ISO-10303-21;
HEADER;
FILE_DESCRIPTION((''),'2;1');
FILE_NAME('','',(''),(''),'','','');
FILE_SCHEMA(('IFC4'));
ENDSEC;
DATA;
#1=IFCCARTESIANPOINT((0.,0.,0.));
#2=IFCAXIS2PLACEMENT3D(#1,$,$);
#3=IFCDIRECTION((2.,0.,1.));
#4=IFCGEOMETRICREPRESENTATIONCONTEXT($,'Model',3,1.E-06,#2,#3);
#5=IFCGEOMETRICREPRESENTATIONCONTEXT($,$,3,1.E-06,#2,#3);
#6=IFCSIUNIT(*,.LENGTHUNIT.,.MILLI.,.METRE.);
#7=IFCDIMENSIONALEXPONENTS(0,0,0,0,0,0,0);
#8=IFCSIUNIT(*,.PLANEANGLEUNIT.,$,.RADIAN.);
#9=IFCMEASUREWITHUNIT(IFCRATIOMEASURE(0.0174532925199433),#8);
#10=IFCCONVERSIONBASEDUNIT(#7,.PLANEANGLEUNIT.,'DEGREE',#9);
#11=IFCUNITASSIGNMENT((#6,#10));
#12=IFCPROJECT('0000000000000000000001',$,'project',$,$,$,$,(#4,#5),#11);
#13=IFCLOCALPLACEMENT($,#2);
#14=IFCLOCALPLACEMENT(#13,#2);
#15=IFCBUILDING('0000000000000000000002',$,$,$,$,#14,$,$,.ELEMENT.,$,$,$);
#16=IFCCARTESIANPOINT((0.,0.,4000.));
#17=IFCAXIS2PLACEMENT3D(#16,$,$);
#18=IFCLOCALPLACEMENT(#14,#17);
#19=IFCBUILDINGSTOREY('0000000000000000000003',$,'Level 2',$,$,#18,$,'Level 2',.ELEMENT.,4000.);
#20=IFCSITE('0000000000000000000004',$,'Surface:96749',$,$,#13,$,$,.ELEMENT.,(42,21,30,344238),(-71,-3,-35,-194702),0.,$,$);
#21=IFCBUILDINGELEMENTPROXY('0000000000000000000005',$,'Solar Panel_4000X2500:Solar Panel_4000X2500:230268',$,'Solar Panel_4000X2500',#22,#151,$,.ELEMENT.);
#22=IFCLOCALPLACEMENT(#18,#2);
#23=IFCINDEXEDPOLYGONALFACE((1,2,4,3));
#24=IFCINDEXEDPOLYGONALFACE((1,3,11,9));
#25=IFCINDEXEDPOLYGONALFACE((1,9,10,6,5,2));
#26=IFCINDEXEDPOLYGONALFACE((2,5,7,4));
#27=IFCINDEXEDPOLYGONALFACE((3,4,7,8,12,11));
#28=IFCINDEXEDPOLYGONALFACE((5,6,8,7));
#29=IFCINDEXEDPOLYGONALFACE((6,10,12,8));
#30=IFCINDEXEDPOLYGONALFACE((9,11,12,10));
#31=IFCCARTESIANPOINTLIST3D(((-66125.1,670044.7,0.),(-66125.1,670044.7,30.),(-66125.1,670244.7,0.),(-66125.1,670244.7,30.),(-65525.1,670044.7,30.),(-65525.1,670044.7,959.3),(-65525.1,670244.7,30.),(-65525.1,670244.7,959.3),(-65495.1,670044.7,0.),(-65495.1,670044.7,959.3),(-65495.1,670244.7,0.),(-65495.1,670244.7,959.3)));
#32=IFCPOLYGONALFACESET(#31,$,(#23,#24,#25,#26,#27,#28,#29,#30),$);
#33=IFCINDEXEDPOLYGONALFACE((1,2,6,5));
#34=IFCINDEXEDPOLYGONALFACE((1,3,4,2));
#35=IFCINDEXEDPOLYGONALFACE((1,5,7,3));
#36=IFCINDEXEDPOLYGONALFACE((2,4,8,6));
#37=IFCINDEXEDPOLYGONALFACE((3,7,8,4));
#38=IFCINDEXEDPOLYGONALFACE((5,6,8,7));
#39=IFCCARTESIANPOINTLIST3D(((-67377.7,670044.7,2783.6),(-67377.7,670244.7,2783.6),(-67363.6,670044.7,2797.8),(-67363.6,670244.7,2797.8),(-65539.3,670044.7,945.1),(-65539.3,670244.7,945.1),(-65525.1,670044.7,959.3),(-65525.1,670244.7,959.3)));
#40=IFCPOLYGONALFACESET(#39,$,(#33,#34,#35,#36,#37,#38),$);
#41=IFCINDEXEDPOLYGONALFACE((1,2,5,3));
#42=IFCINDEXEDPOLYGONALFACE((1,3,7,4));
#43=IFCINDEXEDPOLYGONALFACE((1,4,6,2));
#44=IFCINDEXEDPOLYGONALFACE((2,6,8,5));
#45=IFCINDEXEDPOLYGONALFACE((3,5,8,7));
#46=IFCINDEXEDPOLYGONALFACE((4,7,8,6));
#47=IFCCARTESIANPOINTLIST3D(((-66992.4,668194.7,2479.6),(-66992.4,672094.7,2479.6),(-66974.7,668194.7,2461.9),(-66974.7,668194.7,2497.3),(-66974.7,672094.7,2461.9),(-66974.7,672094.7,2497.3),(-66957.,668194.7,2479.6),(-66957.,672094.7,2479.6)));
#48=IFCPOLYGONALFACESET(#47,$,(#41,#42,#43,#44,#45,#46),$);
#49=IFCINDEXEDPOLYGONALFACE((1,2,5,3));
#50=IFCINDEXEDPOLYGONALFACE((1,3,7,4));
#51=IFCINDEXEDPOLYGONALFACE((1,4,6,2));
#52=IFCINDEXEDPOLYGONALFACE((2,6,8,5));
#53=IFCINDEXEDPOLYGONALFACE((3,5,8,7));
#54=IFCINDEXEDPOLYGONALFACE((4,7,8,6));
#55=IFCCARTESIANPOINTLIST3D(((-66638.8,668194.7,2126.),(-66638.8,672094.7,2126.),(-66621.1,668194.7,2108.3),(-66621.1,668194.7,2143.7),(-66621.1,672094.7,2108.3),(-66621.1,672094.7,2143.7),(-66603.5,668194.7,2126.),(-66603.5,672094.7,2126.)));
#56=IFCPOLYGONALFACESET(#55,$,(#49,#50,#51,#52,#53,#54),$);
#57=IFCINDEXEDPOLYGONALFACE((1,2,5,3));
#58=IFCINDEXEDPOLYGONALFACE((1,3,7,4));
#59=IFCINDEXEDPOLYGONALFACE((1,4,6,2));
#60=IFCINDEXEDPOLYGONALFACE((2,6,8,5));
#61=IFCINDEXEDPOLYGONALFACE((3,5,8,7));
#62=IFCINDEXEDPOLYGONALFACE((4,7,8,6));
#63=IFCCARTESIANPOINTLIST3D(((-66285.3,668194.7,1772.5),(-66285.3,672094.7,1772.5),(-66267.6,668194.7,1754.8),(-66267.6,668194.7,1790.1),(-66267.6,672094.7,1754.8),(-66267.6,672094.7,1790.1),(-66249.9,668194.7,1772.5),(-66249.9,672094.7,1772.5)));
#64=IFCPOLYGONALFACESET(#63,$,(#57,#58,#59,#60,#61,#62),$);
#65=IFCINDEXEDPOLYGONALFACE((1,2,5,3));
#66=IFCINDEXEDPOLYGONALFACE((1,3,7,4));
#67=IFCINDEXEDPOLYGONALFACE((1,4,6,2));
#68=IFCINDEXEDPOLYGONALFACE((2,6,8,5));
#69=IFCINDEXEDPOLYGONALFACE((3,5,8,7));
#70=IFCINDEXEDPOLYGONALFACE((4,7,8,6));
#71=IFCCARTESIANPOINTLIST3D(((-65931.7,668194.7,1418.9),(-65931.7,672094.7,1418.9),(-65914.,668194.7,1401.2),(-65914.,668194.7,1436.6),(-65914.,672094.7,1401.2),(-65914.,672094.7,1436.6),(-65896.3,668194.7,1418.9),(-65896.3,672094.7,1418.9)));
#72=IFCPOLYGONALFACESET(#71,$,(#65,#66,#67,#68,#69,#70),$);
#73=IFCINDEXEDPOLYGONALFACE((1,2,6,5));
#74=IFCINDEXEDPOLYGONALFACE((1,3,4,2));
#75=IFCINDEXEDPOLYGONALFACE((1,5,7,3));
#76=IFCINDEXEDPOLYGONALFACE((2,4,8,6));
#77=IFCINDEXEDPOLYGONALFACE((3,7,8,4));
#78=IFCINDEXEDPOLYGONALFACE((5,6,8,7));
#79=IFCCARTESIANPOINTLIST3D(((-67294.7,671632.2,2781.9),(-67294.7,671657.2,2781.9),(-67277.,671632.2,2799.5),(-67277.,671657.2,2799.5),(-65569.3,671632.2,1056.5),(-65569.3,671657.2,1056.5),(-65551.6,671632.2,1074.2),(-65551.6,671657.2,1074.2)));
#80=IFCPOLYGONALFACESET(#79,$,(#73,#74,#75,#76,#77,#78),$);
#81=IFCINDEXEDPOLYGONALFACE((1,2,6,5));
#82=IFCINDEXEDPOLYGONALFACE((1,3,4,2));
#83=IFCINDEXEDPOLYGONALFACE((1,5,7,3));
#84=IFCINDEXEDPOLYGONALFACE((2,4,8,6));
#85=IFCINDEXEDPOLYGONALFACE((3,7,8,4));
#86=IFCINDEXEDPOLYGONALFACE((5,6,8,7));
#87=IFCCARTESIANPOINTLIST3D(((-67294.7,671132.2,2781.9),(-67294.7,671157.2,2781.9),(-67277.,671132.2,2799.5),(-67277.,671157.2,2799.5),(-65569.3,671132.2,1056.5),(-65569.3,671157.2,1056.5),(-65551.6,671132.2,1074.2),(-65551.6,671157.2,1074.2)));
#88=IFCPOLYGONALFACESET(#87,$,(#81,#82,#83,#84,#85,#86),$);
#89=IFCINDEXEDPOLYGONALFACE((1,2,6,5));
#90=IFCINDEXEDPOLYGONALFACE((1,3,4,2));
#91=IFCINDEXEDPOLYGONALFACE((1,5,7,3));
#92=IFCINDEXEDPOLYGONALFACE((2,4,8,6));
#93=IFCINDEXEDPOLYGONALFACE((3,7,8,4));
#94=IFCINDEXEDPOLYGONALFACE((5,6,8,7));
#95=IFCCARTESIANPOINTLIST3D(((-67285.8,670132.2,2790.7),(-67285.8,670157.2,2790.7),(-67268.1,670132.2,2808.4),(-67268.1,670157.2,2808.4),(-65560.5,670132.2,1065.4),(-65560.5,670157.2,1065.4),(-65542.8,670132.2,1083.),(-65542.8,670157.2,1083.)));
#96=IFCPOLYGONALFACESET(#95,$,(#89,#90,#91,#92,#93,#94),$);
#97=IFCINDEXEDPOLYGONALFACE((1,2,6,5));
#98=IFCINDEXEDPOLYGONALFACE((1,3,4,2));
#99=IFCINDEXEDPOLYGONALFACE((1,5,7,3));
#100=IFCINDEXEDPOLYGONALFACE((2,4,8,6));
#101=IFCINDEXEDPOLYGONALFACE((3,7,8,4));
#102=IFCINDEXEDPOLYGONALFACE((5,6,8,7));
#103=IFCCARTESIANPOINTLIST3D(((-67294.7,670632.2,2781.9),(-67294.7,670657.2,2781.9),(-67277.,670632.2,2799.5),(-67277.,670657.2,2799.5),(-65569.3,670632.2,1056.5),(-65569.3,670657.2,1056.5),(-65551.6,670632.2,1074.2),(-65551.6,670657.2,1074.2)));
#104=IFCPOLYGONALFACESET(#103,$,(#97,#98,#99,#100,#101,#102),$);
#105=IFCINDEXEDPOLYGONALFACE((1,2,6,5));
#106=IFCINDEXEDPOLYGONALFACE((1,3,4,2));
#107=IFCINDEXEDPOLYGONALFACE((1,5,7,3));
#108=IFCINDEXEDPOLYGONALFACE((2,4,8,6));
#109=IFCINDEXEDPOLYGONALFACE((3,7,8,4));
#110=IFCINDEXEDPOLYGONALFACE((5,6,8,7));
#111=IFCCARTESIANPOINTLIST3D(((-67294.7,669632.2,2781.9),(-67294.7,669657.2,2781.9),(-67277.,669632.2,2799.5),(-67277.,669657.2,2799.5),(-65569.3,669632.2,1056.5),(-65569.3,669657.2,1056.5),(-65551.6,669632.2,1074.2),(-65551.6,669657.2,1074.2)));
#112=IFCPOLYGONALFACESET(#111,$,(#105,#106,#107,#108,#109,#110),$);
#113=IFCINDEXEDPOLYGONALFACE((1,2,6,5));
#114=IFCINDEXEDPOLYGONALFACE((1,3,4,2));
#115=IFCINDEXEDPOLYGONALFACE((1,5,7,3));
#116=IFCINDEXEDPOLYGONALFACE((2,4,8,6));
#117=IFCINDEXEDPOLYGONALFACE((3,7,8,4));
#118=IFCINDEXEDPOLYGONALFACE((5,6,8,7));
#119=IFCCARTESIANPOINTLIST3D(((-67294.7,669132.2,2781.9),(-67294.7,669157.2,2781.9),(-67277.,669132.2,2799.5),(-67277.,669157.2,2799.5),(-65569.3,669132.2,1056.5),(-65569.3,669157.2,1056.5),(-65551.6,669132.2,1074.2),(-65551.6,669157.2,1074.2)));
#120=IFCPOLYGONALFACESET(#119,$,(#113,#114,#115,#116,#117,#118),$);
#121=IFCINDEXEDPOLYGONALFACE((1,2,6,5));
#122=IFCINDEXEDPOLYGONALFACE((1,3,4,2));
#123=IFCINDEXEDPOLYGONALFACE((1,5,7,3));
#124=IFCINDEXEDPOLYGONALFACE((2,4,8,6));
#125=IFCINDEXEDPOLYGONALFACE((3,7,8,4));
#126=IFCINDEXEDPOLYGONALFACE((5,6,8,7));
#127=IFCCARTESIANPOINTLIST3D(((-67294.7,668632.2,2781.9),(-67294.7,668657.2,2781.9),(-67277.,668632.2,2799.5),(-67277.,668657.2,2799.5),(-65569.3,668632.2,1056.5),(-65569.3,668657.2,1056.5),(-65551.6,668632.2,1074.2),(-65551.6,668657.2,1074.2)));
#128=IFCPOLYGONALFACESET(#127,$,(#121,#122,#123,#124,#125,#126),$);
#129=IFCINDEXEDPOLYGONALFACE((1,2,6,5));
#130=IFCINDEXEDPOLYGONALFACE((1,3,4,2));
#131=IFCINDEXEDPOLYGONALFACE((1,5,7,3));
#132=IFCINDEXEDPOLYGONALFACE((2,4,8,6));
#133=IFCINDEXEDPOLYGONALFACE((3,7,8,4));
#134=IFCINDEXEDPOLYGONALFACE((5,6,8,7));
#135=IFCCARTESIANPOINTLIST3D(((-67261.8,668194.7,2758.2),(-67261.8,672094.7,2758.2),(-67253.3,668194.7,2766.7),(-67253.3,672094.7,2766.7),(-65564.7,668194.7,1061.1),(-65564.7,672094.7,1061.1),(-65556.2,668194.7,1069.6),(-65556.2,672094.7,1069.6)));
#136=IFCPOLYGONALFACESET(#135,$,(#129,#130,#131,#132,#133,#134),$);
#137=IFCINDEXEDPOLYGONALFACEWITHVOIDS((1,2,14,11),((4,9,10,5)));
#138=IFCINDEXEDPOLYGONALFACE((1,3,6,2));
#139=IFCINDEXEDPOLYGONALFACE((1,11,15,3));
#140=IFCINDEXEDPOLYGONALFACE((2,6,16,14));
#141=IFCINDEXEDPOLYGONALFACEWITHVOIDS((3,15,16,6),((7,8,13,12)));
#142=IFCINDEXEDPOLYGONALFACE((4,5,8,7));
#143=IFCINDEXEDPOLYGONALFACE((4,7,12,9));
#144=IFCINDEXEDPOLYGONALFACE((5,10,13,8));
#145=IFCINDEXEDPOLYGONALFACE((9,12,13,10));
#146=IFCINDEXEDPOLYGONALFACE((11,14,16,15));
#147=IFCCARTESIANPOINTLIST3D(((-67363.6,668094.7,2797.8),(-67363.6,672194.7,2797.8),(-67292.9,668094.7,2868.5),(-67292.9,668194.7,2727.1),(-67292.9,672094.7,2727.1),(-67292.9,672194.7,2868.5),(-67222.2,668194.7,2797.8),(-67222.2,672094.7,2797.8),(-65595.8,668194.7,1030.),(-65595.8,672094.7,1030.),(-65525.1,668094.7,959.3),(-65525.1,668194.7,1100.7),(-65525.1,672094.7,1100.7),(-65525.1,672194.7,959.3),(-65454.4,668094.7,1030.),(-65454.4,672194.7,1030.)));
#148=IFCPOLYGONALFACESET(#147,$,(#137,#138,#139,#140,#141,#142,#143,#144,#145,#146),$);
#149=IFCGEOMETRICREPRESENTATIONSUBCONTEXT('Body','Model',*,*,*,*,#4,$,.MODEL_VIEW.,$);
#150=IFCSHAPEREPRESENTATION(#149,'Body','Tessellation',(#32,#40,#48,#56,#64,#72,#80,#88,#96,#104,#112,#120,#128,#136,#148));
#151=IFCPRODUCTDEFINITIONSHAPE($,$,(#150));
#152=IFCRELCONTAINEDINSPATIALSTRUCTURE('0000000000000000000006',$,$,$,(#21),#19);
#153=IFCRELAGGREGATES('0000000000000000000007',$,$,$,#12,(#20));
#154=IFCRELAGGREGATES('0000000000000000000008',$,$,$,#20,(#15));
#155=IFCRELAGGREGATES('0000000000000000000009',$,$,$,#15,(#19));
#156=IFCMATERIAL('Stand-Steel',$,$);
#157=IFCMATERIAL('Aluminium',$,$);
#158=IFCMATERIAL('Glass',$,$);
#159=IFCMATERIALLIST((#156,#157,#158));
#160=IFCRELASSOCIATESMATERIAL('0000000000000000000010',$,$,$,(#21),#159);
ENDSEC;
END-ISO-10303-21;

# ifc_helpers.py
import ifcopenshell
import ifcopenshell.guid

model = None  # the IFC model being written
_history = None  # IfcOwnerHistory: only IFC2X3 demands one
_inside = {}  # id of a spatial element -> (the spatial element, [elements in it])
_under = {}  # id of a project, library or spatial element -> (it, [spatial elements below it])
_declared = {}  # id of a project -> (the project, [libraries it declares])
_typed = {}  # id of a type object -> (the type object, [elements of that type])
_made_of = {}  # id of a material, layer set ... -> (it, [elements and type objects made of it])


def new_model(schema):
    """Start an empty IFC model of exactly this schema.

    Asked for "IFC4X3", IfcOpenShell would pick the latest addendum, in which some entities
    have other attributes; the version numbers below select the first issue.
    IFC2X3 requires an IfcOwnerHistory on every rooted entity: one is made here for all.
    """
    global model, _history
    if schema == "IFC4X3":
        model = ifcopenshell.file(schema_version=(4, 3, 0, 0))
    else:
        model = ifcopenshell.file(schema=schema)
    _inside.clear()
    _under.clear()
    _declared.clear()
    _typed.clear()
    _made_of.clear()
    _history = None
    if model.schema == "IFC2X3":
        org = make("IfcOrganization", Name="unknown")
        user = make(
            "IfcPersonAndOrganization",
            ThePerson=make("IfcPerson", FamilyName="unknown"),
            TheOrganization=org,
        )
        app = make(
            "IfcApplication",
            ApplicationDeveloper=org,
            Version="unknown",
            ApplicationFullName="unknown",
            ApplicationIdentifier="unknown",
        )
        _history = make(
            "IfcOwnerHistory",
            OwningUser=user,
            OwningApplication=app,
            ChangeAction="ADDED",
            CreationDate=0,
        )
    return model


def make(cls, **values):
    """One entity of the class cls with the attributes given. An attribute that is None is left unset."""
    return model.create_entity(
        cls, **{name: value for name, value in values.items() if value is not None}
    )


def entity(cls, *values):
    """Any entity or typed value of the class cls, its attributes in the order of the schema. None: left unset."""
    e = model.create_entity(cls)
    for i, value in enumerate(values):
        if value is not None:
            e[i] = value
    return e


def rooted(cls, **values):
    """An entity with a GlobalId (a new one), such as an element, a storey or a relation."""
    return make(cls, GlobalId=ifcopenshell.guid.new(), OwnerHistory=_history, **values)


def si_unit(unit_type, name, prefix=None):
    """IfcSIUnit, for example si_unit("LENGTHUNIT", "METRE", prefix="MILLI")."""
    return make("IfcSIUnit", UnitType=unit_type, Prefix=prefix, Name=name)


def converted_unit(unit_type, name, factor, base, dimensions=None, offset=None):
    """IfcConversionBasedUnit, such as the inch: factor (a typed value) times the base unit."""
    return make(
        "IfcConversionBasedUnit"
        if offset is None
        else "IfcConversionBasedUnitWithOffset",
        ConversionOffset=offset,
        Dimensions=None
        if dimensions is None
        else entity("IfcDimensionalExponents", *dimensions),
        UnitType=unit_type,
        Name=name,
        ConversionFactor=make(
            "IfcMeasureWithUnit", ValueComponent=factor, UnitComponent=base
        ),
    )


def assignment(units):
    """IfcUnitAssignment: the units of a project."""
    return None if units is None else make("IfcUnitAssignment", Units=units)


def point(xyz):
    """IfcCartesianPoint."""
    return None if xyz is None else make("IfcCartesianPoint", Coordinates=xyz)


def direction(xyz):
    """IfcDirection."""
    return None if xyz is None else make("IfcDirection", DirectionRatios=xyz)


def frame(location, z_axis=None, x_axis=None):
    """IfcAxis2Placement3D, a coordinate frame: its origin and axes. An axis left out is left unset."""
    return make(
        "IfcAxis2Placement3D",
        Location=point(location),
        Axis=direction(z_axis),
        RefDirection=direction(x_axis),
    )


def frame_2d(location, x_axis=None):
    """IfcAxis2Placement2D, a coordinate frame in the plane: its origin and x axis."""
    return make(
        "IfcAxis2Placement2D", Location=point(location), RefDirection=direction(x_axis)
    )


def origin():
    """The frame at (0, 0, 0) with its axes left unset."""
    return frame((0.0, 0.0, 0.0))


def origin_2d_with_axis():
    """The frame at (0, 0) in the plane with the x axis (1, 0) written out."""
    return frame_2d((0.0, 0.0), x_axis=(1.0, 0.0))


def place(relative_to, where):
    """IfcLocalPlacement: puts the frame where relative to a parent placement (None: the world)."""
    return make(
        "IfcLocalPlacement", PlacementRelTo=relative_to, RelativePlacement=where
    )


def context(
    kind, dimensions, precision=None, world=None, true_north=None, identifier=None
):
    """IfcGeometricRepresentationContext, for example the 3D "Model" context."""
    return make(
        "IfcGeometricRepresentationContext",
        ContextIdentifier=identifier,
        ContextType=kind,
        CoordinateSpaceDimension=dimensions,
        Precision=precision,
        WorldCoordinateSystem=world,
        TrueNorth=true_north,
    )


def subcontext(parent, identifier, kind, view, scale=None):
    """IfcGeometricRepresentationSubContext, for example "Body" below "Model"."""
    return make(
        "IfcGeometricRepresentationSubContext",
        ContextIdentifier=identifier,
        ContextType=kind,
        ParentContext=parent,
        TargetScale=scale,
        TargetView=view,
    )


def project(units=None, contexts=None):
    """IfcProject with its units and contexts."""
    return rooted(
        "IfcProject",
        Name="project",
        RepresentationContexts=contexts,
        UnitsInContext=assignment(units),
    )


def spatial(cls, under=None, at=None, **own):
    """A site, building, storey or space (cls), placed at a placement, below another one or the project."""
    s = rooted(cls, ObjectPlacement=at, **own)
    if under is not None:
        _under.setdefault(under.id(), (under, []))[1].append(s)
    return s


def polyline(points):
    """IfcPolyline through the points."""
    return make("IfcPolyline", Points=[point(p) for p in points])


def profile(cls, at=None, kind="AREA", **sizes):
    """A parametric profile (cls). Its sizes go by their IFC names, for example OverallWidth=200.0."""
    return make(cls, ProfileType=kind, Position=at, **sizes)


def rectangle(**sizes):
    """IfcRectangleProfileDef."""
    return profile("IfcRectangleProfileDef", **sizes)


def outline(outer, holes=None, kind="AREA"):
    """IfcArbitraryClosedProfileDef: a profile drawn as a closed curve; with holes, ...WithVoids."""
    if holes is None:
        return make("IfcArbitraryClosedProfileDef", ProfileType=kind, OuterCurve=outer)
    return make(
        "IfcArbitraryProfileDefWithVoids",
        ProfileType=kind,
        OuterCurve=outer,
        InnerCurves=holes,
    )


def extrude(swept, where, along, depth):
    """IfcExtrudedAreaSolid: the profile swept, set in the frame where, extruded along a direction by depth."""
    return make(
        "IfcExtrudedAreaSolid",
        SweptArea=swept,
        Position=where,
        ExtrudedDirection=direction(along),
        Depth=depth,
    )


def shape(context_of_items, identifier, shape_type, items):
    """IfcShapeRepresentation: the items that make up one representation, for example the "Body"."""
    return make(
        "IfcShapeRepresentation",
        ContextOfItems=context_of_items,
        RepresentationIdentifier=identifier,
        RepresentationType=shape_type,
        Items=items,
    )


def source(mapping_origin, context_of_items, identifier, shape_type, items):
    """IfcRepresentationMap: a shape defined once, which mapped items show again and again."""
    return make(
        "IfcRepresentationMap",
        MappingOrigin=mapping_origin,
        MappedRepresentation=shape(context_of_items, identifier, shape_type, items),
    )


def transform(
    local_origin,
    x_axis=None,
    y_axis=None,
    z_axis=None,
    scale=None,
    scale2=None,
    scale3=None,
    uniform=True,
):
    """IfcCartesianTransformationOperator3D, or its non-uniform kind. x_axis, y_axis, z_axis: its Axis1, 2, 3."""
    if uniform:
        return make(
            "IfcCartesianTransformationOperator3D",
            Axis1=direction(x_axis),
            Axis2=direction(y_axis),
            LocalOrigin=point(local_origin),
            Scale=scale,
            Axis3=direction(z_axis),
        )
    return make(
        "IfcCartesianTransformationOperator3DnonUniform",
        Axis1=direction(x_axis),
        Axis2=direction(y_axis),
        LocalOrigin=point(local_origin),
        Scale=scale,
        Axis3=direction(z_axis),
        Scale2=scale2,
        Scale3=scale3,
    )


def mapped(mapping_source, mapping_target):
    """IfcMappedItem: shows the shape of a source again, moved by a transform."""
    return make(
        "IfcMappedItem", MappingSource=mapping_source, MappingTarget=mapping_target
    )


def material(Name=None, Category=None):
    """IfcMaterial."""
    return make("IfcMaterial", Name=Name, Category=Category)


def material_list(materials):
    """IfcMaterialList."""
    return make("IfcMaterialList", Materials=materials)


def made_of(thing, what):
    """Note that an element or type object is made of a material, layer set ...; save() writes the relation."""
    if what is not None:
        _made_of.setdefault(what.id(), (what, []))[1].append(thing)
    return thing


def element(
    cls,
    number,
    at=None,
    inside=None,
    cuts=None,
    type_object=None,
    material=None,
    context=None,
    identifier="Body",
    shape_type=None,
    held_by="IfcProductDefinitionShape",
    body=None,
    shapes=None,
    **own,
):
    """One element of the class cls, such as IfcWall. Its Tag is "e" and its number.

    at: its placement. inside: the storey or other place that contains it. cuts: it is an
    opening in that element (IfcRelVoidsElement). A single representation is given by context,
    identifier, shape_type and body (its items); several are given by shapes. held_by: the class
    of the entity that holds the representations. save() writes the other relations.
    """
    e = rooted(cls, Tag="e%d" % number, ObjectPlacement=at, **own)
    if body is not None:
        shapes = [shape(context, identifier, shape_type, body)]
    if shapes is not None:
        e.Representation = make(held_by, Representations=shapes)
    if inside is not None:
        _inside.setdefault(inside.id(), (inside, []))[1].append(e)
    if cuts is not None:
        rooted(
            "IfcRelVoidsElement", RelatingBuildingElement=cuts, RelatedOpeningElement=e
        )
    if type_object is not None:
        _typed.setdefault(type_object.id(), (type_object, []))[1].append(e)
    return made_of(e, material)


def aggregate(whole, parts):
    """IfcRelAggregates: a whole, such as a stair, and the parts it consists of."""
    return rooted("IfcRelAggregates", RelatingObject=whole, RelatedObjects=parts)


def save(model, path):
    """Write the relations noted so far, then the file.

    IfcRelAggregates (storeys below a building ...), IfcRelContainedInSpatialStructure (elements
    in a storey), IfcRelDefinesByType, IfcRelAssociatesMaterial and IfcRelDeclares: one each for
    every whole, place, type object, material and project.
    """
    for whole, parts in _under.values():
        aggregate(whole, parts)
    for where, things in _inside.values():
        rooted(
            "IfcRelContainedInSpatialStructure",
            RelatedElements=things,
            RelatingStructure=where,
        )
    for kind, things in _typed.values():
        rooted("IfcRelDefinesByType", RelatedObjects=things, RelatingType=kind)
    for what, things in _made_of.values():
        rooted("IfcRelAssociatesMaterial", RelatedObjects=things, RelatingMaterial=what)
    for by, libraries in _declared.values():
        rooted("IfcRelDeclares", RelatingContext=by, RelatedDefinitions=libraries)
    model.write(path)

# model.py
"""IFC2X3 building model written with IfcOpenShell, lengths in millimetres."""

from ifc_helpers import new_model, entity, si_unit, converted_unit, direction, frame, frame_2d, origin, origin_2d_with_axis, place, context, subcontext, project, spatial, polyline, rectangle, outline, extrude, source, transform, mapped, material, material_list, element, save


model = new_model("IFC2X3")

# Units and contexts
model_context = context("Model", 3, precision=1e-06, world=origin(), true_north=direction((2.0, 0.0, 1.0)))
context_of_model = context(None, 3, precision=1e-06, world=origin(), true_north=direction((2.0, 0.0, 1.0)))
body_context = subcontext(model_context, "Body", "Model", "MODEL_VIEW")
ifc_project = project(units=[si_unit("LENGTHUNIT", "METRE", prefix="MILLI"), converted_unit("PLANEANGLEUNIT", "DEGREE", entity("IfcRatioMeasure", 0.0174532925199433), si_unit("PLANEANGLEUNIT", "RADIAN"), dimensions=[0, 0, 0, 0, 0, 0, 0])], contexts=[model_context, context_of_model])

# Site, building, storey
site_placement = place(None, origin())
site = spatial("IfcSite", under=ifc_project, at=site_placement, Name="Surface:96749", CompositionType="ELEMENT", RefLatitude=(42, 21, 30, 344238), RefLongitude=(-71, -3, -35, -194702), RefElevation=0.0)
building_placement = place(site_placement, origin())
building = spatial("IfcBuilding", under=site, at=building_placement, CompositionType="ELEMENT")
storey_placement = place(building_placement, frame((0.0, 0.0, 4000.0)))
storey = spatial("IfcBuildingStorey", under=building, at=storey_placement, Name="Level 2", LongName="Level 2", CompositionType="ELEMENT", Elevation=4000.0)

# Building element proxy
ifc_material_1 = material(Name="Stand-Steel")
ifc_material_2 = material(Name="Aluminium")
ifc_material_3 = material(Name="Glass")
ifc_material_list_1 = material_list([ifc_material_1, ifc_material_2, ifc_material_3])
shared_shape = source(origin(), body_context, "Body", "SweptSolid", [
    extrude(outline(polyline([(-629.5, -220.0), (329.8, -220.0), (329.8, 410.0), (299.8, 410.0), (299.8, -190.0), (-629.5, -190.0), (-629.5, -220.0)])), frame((-190.0, -100.0, 299.8), z_axis=(0.0, 1.0, 0.0), x_axis=(0.0, 0.0, -1.0)), (0.0, 0.0, 1.0), 200.0),
    extrude(rectangle(XDim=20.0, YDim=200.0, at=frame_2d((0.0, 0.0), x_axis=(0.0, 1.0))), frame((-7.1, 0.0, 922.2), z_axis=(-0.707107, 0.0, 0.707107), x_axis=(0.0, 1.0, 0.0)), (0.0, 0.0, 1.0), 2600.0),
    extrude(rectangle(XDim=25.0, YDim=25.0, at=frame_2d((0.0, 0.0), x_axis=(1.0, 0.0))), frame((-1449.6, -1950.0, 2449.6), z_axis=(0.0, 1.0, 0.0), x_axis=(-0.707107, 0.0, -0.707107)), (0.0, 0.0, 1.0), 3900.0),
    extrude(rectangle(XDim=25.0, YDim=25.0, at=origin_2d_with_axis()), frame((-1096.0, -1950.0, 2096.0), z_axis=(0.0, 1.0, 0.0), x_axis=(-0.707107, 0.0, -0.707107)), (0.0, 0.0, 1.0), 3900.0),
    extrude(rectangle(XDim=25.0, YDim=25.0, at=origin_2d_with_axis()), frame((-742.5, -1950.0, 1742.5), z_axis=(0.0, 1.0, 0.0), x_axis=(-0.707107, 0.0, -0.707107)), (0.0, 0.0, 1.0), 3900.0),
    extrude(rectangle(XDim=25.0, YDim=25.0, at=frame_2d((0.0, 0.0), x_axis=(1.0, 0.0))), frame((-388.9, -1950.0, 1388.9), z_axis=(0.0, 1.0, 0.0), x_axis=(-0.707107, 0.0, -0.707107)), (0.0, 0.0, 1.0), 3900.0),
    extrude(rectangle(XDim=25.0, YDim=25.0, at=frame_2d((0.0, 0.0), x_axis=(0.0, 1.0))), frame((-35.4, 1500.0, 1035.4), z_axis=(-0.707107, 0.0, 0.707107), x_axis=(0.0, 1.0, 0.0)), (0.0, 0.0, 1.0), 2440.0),
    extrude(rectangle(XDim=25.0, YDim=25.0, at=frame_2d((0.0, 0.0), x_axis=(0.0, 1.0))), frame((-35.4, 1000.0, 1035.4), z_axis=(-0.707107, 0.0, 0.707107), x_axis=(0.0, 1.0, 0.0)), (0.0, 0.0, 1.0), 2440.0),
    extrude(rectangle(XDim=25.0, YDim=25.0, at=frame_2d((0.0, 0.0), x_axis=(0.0, 1.0))), frame((-26.5, 0.0, 1044.2), z_axis=(-0.707107, 0.0, 0.707107), x_axis=(0.0, -1.0, 0.0)), (0.0, 0.0, 1.0), 2440.0),
    extrude(rectangle(XDim=25.0, YDim=25.0, at=frame_2d((0.0, 0.0), x_axis=(0.0, 1.0))), frame((-35.4, 500.0, 1035.4), z_axis=(-0.707107, 0.0, 0.707107), x_axis=(0.0, 1.0, 0.0)), (0.0, 0.0, 1.0), 2440.0),
    extrude(rectangle(XDim=25.0, YDim=25.0, at=frame_2d((0.0, 0.0), x_axis=(0.0, 1.0))), frame((-35.4, -500.0, 1035.4), z_axis=(-0.707107, 0.0, 0.707107), x_axis=(0.0, 1.0, 0.0)), (0.0, 0.0, 1.0), 2440.0),
    extrude(rectangle(XDim=25.0, YDim=25.0, at=frame_2d((0.0, 0.0), x_axis=(0.0, 1.0))), frame((-35.4, -1000.0, 1035.4), z_axis=(-0.707107, 0.0, 0.707107), x_axis=(0.0, 1.0, 0.0)), (0.0, 0.0, 1.0), 2440.0),
    extrude(rectangle(XDim=25.0, YDim=25.0, at=frame_2d((0.0, 0.0), x_axis=(0.0, 1.0))), frame((-35.4, -1500.0, 1035.4), z_axis=(-0.707107, 0.0, 0.707107), x_axis=(0.0, 1.0, 0.0)), (0.0, 0.0, 1.0), 2440.0),
    extrude(rectangle(XDim=2400.0, YDim=12.0, at=frame_2d((0.0, 0.0), x_axis=(1.0, 0.0))), frame((-883.9, -1950.0, 1883.9), z_axis=(0.0, 1.0, 0.0), x_axis=(0.707107, 0.0, -0.707107)), (0.0, 0.0, 1.0), 3900.0),
    extrude(outline(polyline([(-2050.0, -1300.0), (2050.0, -1300.0), (2050.0, 1300.0), (-2050.0, 1300.0), (-2050.0, -1300.0)]), holes=[polyline([(1950.0, -1200.0), (-1950.0, -1200.0), (-1950.0, 1200.0), (1950.0, 1200.0), (1950.0, -1200.0)])]), frame((-919.2, 0.0, 1848.5), z_axis=(0.707107, 0.0, 0.707107), x_axis=(0.0, 1.0, 0.0)), (0.0, 0.0, 1.0), 100.0),
])
proxy_1_placement = place(storey_placement, frame((-65525.1, 670144.7, 30.0)))
element("IfcBuildingElementProxy", 1, at=proxy_1_placement, inside=storey, material=ifc_material_list_1, Name="Solar Panel_4000X2500:Solar Panel_4000X2500:230268", ObjectType="Solar Panel_4000X2500", CompositionType="ELEMENT", context=body_context, shape_type="MappedRepresentation", body=[
    mapped(shared_shape, transform((0.0, 0.0, 0.0), scale=1.0)),
])

save(model, "model.ifc")
